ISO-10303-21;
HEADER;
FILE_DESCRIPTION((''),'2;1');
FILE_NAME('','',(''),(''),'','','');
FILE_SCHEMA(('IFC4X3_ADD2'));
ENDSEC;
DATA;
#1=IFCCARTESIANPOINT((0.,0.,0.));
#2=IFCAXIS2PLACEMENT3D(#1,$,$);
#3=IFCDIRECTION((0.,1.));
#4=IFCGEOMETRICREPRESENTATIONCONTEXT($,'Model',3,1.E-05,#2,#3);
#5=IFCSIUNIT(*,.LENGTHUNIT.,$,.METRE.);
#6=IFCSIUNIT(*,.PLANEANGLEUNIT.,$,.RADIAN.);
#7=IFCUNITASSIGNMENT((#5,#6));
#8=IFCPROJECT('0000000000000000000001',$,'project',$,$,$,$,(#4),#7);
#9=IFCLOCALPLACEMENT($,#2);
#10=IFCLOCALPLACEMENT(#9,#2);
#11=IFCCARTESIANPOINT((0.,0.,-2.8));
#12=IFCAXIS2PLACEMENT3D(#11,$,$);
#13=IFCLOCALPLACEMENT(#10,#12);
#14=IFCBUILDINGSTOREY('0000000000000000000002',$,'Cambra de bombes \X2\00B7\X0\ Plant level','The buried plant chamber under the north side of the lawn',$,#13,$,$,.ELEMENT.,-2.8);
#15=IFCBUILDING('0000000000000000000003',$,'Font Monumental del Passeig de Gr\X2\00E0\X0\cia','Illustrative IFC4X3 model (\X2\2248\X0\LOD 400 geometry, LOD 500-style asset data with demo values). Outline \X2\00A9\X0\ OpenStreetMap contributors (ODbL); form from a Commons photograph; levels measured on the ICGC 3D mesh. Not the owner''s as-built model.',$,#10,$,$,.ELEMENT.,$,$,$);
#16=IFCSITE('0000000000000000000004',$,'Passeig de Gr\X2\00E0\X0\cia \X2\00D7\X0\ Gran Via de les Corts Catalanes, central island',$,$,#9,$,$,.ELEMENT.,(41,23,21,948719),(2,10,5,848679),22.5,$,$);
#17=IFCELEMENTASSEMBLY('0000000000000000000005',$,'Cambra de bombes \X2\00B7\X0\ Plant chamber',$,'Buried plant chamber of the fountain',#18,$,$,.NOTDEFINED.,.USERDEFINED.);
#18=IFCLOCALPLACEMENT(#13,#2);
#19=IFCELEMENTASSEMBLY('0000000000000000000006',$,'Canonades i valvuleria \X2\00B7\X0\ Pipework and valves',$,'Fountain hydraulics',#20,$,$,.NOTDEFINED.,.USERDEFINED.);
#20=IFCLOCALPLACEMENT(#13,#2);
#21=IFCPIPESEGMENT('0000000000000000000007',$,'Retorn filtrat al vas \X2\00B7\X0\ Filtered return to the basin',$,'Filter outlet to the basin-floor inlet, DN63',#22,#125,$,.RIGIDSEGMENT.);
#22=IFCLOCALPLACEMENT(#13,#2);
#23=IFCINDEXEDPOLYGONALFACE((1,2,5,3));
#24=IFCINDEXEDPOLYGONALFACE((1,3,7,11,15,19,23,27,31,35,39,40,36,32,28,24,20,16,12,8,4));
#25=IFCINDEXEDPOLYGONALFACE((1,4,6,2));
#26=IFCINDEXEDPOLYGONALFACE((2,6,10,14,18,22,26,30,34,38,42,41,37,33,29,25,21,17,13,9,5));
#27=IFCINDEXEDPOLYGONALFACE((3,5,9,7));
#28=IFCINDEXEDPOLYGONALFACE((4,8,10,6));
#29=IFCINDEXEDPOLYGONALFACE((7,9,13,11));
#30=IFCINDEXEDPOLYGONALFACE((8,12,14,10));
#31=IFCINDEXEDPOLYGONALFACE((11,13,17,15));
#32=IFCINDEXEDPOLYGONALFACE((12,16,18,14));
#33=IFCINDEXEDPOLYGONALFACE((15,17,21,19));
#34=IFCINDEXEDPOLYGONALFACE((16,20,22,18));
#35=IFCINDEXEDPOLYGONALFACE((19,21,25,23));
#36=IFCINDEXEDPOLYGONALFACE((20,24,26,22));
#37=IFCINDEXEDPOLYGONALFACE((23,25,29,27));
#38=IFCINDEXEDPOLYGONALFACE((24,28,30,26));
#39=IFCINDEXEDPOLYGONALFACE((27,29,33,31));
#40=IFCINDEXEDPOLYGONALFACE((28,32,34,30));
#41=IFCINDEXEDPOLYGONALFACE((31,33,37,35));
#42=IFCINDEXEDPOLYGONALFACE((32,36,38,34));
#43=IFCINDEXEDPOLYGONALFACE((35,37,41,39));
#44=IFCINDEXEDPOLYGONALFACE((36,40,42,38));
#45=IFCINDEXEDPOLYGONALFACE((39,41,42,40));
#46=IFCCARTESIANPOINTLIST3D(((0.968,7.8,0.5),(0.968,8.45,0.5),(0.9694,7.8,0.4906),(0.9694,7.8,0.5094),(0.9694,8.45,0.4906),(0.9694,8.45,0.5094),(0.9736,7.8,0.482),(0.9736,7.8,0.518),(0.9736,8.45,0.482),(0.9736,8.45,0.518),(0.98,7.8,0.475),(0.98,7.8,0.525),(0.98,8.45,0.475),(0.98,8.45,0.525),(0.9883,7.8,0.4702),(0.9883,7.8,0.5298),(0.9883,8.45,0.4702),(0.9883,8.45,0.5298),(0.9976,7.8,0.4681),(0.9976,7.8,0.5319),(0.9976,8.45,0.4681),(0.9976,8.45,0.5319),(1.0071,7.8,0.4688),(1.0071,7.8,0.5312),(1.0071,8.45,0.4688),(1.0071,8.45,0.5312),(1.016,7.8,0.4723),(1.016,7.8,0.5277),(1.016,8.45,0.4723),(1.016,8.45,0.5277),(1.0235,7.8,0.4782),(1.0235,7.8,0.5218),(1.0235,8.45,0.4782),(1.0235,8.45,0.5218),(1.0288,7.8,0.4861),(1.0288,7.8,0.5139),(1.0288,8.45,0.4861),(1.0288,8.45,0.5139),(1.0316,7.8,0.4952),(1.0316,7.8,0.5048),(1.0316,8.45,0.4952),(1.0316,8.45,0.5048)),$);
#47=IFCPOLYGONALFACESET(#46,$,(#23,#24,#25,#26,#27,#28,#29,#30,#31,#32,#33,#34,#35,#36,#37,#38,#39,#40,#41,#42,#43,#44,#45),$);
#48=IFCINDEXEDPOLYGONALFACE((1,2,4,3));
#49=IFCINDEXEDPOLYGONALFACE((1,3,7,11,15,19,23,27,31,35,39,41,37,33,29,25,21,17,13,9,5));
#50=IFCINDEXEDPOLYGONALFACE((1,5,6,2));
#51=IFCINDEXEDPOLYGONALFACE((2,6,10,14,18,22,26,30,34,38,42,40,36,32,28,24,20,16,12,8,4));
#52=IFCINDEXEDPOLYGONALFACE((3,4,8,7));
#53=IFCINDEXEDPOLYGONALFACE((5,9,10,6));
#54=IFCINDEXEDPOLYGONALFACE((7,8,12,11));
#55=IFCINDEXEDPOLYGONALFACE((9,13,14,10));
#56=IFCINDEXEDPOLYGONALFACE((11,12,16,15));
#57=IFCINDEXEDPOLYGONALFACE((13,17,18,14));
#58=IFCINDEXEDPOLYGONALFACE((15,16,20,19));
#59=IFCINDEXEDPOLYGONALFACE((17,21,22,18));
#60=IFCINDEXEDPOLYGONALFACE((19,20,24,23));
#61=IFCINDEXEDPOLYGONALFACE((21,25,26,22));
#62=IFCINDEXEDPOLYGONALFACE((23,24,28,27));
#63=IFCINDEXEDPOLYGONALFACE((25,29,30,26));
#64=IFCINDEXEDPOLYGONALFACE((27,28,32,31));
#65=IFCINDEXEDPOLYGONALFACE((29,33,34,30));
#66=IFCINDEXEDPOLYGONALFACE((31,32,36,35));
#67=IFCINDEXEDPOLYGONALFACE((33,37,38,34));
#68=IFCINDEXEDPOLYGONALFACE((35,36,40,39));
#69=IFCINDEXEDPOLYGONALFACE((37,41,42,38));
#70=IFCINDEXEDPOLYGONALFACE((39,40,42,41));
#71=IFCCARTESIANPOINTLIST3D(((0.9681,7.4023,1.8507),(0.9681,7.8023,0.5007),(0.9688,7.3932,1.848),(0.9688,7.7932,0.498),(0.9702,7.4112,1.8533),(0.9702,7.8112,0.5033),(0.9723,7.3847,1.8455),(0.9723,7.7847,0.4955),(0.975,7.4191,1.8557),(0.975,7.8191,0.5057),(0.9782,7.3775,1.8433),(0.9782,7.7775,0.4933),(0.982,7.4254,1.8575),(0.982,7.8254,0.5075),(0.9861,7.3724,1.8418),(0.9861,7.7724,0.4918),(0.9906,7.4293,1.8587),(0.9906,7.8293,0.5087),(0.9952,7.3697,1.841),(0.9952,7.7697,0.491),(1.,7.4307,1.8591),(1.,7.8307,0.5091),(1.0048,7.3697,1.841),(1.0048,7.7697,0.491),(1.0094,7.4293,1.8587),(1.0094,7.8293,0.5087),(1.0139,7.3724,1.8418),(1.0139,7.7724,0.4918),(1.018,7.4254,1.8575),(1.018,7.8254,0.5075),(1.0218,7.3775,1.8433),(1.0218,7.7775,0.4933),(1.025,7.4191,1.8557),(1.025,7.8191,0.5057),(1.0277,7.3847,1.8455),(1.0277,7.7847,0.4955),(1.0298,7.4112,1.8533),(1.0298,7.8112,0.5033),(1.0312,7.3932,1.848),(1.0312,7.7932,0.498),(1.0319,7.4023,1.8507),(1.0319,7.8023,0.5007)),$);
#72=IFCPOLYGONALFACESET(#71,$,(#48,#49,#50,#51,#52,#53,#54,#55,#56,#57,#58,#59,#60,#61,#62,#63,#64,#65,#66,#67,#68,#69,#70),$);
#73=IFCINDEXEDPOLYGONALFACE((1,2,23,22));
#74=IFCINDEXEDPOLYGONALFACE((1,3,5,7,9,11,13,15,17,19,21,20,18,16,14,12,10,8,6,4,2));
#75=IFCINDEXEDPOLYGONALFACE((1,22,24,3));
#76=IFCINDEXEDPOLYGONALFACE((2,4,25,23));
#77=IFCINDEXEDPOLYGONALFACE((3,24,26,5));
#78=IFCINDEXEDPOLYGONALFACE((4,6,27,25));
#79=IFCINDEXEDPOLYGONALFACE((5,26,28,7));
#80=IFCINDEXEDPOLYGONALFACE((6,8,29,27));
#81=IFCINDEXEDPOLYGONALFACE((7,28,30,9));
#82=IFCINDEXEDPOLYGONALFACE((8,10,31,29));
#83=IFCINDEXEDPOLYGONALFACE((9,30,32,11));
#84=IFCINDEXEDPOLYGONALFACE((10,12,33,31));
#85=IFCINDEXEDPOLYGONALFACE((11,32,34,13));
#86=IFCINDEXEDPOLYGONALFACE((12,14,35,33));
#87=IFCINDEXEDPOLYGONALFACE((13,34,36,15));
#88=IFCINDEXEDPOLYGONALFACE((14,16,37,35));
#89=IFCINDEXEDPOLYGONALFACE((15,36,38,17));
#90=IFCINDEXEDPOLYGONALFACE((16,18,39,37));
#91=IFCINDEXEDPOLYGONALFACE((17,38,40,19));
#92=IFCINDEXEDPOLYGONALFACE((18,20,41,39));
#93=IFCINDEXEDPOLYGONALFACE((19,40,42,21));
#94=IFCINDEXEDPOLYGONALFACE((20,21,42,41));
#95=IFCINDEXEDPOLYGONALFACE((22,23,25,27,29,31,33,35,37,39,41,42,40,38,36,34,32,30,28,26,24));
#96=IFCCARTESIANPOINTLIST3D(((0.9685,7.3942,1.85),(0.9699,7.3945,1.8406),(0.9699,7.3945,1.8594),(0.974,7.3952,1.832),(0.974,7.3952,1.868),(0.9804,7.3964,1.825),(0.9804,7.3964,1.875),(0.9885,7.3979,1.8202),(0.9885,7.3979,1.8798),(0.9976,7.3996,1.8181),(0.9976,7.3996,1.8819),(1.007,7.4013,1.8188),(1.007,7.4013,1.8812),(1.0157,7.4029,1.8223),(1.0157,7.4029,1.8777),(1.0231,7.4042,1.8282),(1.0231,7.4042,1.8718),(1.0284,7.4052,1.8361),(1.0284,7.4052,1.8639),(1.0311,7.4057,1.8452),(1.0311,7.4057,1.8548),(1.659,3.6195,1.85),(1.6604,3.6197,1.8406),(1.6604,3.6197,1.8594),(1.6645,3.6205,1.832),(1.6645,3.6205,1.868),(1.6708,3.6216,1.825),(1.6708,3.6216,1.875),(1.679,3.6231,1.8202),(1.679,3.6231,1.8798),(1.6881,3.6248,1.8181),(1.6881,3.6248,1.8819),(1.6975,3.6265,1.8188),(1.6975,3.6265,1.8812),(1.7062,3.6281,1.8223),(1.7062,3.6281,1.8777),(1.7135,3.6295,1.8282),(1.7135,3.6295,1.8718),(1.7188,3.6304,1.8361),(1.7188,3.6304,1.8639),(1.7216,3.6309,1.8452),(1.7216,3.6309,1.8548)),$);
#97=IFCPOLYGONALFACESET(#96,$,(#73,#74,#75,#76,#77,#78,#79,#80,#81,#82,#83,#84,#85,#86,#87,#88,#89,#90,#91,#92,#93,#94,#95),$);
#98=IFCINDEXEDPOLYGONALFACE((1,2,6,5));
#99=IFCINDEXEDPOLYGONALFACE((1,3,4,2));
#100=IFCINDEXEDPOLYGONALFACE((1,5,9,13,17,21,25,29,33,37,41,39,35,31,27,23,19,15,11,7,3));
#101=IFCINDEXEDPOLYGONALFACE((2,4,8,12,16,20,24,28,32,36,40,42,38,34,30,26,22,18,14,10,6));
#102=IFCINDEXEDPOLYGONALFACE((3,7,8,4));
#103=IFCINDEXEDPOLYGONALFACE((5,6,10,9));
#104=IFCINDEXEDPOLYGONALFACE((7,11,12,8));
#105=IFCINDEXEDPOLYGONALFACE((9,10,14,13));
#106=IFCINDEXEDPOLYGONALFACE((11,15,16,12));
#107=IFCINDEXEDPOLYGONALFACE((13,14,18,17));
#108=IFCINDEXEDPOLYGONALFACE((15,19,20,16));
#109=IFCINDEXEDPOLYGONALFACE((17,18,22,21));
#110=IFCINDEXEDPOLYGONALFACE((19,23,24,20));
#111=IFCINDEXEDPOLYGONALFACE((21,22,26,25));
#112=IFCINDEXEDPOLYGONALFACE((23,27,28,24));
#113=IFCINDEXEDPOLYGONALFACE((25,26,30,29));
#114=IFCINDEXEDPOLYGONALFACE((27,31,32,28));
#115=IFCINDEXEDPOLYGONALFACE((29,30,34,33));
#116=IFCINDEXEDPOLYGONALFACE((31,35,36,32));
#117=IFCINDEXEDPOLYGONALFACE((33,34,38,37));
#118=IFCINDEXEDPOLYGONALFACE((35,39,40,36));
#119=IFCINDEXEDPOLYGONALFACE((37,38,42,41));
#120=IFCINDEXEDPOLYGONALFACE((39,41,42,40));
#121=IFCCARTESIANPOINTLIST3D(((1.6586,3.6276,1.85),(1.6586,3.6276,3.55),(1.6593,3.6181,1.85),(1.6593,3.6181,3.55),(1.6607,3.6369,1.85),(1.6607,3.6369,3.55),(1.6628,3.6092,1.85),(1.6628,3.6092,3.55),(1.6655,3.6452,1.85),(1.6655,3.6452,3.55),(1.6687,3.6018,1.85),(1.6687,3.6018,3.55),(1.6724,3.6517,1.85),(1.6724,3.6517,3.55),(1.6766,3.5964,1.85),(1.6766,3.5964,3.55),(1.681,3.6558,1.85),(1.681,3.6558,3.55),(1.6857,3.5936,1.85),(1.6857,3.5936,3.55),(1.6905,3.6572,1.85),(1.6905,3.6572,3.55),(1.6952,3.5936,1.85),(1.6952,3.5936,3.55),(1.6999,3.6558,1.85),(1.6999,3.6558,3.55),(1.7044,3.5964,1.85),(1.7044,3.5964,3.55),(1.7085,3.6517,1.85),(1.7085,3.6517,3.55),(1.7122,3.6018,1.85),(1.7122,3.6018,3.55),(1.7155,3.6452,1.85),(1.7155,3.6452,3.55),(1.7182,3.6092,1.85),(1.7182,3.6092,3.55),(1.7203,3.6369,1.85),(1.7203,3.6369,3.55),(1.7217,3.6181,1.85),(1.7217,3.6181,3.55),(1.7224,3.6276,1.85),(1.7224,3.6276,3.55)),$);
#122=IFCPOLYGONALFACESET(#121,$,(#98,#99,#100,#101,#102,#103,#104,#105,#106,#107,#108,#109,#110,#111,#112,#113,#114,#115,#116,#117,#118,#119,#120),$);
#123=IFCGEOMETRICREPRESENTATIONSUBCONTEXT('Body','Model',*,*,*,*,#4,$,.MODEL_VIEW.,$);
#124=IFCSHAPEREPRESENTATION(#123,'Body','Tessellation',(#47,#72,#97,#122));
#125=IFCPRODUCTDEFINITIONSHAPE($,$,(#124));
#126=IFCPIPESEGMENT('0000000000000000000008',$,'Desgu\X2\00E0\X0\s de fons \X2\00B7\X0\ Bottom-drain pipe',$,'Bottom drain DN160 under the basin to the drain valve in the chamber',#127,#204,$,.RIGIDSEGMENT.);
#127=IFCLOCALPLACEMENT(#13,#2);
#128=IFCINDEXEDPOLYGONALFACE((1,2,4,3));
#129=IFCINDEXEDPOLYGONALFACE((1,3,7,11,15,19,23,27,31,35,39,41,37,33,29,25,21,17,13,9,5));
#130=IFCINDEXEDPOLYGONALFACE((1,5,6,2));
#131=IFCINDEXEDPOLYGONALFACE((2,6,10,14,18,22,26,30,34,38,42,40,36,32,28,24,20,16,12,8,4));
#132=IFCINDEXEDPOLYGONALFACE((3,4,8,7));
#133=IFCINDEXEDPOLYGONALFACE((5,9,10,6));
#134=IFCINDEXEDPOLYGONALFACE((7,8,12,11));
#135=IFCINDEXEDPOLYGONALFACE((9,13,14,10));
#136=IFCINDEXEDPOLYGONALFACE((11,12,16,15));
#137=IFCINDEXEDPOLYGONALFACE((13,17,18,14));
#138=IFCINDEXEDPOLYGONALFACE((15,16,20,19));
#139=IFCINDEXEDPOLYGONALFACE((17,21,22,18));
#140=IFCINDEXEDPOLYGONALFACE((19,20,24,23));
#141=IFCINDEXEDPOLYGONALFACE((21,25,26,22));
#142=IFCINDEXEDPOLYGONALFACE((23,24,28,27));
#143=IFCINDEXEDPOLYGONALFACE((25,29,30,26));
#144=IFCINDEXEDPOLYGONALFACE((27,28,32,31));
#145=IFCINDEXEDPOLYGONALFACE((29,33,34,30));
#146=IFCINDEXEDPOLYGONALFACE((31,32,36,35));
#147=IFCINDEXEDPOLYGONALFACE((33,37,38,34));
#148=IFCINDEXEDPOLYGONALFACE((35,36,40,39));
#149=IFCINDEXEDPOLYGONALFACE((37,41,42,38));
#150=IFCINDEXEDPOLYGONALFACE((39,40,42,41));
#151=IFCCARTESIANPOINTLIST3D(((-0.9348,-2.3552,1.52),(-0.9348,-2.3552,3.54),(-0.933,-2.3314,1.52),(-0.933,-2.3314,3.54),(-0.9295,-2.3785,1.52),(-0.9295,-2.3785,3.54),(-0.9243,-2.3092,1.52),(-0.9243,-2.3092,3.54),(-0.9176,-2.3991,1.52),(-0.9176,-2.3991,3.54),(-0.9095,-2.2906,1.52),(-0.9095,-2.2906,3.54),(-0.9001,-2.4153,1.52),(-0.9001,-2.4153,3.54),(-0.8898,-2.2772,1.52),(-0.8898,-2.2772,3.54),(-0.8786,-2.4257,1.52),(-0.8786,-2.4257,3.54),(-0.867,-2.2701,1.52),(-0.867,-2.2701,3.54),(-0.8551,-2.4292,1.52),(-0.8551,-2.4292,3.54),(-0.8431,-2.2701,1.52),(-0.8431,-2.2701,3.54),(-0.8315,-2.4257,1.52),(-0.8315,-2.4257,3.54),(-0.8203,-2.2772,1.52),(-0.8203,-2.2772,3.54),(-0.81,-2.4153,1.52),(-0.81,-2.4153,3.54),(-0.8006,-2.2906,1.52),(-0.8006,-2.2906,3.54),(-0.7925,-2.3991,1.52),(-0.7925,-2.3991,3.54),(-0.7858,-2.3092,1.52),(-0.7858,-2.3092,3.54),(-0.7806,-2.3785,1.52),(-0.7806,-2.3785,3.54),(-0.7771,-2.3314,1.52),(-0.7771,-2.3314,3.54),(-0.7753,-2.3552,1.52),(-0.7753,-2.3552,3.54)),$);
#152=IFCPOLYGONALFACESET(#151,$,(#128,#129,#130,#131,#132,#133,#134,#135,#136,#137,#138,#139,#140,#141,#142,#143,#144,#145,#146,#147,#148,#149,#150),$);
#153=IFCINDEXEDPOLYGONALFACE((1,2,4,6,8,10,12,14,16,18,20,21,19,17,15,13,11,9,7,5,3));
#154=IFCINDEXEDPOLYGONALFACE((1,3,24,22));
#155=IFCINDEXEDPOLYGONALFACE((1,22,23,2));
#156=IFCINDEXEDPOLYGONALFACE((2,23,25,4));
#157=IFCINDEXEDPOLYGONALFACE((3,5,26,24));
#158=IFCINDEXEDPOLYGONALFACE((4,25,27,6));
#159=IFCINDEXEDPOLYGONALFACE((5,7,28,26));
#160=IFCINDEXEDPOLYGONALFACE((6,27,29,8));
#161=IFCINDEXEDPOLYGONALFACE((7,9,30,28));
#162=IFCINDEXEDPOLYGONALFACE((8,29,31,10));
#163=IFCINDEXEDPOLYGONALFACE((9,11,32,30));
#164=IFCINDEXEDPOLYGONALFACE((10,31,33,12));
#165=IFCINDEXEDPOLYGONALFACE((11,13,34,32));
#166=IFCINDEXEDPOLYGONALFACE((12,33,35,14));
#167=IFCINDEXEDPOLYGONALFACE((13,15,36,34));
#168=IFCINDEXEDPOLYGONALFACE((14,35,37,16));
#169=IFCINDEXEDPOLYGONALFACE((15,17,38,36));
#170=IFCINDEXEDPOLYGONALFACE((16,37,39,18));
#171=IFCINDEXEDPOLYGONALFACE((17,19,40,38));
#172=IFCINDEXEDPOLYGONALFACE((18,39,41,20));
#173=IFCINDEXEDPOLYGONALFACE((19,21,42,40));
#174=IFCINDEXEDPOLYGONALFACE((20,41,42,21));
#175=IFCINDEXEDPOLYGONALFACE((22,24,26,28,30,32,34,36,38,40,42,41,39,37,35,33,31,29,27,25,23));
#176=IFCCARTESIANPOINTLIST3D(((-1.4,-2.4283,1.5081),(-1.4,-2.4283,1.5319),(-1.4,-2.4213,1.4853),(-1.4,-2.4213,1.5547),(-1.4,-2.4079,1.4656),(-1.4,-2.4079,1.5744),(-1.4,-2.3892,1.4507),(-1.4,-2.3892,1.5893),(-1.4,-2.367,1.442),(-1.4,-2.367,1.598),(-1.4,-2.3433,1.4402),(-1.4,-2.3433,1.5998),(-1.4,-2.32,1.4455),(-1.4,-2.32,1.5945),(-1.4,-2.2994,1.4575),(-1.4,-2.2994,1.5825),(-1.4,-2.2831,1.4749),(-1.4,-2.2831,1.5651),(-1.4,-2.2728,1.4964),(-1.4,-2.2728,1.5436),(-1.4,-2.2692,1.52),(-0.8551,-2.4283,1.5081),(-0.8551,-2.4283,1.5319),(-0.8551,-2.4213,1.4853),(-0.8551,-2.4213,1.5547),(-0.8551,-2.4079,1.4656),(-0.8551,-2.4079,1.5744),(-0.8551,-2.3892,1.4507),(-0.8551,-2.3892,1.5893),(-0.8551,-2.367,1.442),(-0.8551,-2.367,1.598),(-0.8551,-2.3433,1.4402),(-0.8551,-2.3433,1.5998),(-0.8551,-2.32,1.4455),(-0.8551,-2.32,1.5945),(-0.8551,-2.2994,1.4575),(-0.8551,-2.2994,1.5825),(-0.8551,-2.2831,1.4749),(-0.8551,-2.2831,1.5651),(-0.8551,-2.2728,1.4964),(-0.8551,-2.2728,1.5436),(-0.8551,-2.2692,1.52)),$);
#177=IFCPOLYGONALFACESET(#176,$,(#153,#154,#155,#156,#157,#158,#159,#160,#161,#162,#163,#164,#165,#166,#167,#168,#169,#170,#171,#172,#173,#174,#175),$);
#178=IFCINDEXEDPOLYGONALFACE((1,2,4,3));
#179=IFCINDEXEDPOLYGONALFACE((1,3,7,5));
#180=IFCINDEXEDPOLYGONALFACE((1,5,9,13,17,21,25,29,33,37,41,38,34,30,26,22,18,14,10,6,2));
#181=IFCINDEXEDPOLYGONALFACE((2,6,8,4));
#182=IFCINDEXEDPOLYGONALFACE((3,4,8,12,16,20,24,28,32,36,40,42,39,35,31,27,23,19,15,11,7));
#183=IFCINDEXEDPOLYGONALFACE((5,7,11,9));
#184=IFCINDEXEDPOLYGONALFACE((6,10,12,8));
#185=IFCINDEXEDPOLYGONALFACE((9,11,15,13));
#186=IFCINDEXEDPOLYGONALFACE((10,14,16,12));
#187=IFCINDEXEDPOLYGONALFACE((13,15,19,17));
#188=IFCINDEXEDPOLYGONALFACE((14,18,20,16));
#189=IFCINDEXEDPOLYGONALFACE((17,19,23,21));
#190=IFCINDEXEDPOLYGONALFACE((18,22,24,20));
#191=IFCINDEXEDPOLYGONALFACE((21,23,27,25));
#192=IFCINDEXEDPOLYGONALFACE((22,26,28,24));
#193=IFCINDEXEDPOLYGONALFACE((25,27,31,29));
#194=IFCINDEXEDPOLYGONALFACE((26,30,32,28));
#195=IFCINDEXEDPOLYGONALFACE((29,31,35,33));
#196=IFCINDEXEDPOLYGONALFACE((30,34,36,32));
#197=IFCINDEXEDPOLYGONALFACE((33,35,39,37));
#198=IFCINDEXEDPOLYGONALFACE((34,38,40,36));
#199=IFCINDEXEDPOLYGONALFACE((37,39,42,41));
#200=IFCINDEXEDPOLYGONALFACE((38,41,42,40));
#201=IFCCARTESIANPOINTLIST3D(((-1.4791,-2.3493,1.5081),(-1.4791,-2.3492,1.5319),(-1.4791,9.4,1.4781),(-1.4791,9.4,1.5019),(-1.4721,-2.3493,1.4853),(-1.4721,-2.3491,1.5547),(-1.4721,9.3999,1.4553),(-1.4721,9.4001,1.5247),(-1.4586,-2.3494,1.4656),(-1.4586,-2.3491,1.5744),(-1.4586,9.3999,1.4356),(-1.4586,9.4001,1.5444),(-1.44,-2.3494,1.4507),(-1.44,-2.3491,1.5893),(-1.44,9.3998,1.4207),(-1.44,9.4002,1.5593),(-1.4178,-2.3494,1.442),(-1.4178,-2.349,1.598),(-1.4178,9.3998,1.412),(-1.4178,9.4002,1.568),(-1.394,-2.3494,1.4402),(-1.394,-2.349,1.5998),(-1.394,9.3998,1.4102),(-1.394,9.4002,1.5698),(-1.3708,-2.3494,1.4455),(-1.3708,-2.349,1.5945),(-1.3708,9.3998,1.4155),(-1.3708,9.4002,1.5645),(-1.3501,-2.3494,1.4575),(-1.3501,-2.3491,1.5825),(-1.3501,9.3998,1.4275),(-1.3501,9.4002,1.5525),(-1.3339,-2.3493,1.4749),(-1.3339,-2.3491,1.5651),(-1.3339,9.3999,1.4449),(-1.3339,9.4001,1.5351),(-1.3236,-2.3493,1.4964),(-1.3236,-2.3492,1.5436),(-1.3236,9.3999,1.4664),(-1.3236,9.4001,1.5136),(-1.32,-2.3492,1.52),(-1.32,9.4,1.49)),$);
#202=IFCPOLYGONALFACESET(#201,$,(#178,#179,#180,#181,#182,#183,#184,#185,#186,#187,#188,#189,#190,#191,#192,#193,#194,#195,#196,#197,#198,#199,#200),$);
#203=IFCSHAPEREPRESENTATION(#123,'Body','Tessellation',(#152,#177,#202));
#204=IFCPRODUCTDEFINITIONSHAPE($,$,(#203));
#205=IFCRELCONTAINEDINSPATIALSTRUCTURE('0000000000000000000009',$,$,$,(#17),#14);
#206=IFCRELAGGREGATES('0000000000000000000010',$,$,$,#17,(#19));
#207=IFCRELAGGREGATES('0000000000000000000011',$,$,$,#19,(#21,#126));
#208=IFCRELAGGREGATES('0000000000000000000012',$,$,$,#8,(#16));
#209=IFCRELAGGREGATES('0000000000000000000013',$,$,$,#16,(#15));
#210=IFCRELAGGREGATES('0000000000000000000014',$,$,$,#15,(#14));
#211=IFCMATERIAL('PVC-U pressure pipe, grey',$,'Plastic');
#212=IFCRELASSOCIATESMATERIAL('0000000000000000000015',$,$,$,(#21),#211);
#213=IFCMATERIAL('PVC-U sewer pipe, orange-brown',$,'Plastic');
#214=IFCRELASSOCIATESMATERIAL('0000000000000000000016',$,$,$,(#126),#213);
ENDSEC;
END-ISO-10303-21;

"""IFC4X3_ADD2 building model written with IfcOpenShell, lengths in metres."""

from ifc_helpers import new_model, si_unit, direction, frame, origin, origin_2d_with_axis, place, context, subcontext, project, spatial, circle, extrude, material, element, aggregate, save


model = new_model("IFC4X3_ADD2")

# Units and contexts
model_context = context("Model", 3, precision=1e-05, world=origin(), true_north=direction((0.0, 1.0)))
body_context = subcontext(model_context, "Body", "Model", "MODEL_VIEW")
ifc_project = project(units=[si_unit("LENGTHUNIT", "METRE"), si_unit("PLANEANGLEUNIT", "RADIAN")], contexts=[model_context])

# Site, building, storey
site_placement = place(None, origin())
site = spatial("IfcSite", under=ifc_project, at=site_placement, Name="Passeig de Gràcia × Gran Via de les Corts Catalanes, central island", CompositionType="ELEMENT", RefLatitude=(41, 23, 21, 948719), RefLongitude=(2, 10, 5, 848679), RefElevation=22.5)
building_placement = place(site_placement, origin())
building = spatial("IfcBuilding", under=site, at=building_placement, Name="Font Monumental del Passeig de Gràcia", Description="Illustrative IFC4X3 model (≈LOD 400 geometry, LOD 500-style asset data with demo values). Outline © OpenStreetMap contributors (ODbL); form from a Commons photograph; levels measured on the ICGC 3D mesh. Not the owner's as-built model.", CompositionType="ELEMENT")
storey_placement = place(building_placement, frame((0.0, 0.0, -2.8)))
storey = spatial("IfcBuildingStorey", under=building, at=storey_placement, Name="Cambra de bombes · Plant level", Description="The buried plant chamber under the north side of the lawn", CompositionType="ELEMENT", Elevation=-2.8)

# Element assemblies, pipe segments
assembly_1_placement = place(building_placement, origin())
assembly_1 = element("IfcElementAssembly", 1, at=assembly_1_placement, inside=storey, Name="Cambra de bombes · Plant chamber", ObjectType="Buried plant chamber of the fountain", AssemblyPlace="NOTDEFINED", PredefinedType="USERDEFINED")
assembly_2_placement = place(building_placement, origin())
assembly_2 = element("IfcElementAssembly", 2, at=assembly_2_placement, Name="Canonades i valvuleria · Pipework and valves", ObjectType="Fountain hydraulics", AssemblyPlace="NOTDEFINED", PredefinedType="USERDEFINED")
aggregate(assembly_1, [assembly_2])
ifc_material_1 = material(Name="PVC-U pressure pipe, grey", Category="Plastic")
pipe_segment_1_placement = place(building_placement, origin())
pipe_segment_1 = element("IfcPipeSegment", 3, at=pipe_segment_1_placement, material=ifc_material_1, Name="Retorn filtrat al vas · Filtered return to the basin", ObjectType="Filter outlet to the basin-floor inlet, DN63", PredefinedType="RIGIDSEGMENT", context=body_context, shape_type="SweptSolid", body=[
    extrude(circle(Radius=0.032, at=origin_2d_with_axis()), frame((1.0, 8.45, -2.3), z_axis=(0.0, -1.0, 0.0), x_axis=(-1.0, 0.0, 0.0)), (0.0, 0.0, 1.0), 0.65),
    extrude(circle(Radius=0.032, at=origin_2d_with_axis()), frame((1.0, 7.8, -2.3), z_axis=(0.0, -0.284088, 0.958798), x_axis=(0.0, 0.958798, 0.284088)), (0.0, 0.0, 1.0), 1.408),
    extrude(circle(Radius=0.032, at=origin_2d_with_axis()), frame((1.0, 7.4, -0.95), z_axis=(0.179933, -0.983679, 0.0), x_axis=(-0.983679, -0.179933, 0.0)), (0.0, 0.0, 1.0), 3.8374),
    extrude(circle(Radius=0.032, at=origin_2d_with_axis()), frame((1.6905, 3.6252, -0.95), z_axis=(0.0, 0.0, 1.0), x_axis=(0.0, 1.0, 0.0)), (0.0, 0.0, 1.0), 1.7),
])
ifc_material_2 = material(Name="PVC-U sewer pipe, orange-brown", Category="Plastic")
pipe_segment_2_placement = place(building_placement, origin())
pipe_segment_2 = element("IfcPipeSegment", 4, at=pipe_segment_2_placement, material=ifc_material_2, Name="Desguàs de fons · Bottom-drain pipe", ObjectType="Bottom drain DN160 under the basin to the drain valve in the chamber", PredefinedType="RIGIDSEGMENT", context=body_context, shape_type="SweptSolid", body=[
    extrude(circle(Radius=0.08, at=origin_2d_with_axis()), frame((-0.8551, -2.3492, 0.74), z_axis=(0.0, 0.0, -1.0), x_axis=(0.0, -1.0, 0.0)), (0.0, 0.0, 1.0), 2.02),
    extrude(circle(Radius=0.08, at=origin_2d_with_axis()), frame((-0.8551, -2.3492, -1.28), z_axis=(-1.0, 0.0, 0.0), x_axis=(0.0, 1.0, 0.0)), (0.0, 0.0, 1.0), 0.5449),
    extrude(circle(Radius=0.08, at=origin_2d_with_axis()), frame((-1.4, -2.3492, -1.28), z_axis=(0.0, 0.999997, -0.002553), x_axis=(1.0, 0.0, 0.0)), (0.0, 0.0, 1.0), 11.7493),
])
aggregate(assembly_2, [pipe_segment_1, pipe_segment_2])

save(model, "model.ifc")
